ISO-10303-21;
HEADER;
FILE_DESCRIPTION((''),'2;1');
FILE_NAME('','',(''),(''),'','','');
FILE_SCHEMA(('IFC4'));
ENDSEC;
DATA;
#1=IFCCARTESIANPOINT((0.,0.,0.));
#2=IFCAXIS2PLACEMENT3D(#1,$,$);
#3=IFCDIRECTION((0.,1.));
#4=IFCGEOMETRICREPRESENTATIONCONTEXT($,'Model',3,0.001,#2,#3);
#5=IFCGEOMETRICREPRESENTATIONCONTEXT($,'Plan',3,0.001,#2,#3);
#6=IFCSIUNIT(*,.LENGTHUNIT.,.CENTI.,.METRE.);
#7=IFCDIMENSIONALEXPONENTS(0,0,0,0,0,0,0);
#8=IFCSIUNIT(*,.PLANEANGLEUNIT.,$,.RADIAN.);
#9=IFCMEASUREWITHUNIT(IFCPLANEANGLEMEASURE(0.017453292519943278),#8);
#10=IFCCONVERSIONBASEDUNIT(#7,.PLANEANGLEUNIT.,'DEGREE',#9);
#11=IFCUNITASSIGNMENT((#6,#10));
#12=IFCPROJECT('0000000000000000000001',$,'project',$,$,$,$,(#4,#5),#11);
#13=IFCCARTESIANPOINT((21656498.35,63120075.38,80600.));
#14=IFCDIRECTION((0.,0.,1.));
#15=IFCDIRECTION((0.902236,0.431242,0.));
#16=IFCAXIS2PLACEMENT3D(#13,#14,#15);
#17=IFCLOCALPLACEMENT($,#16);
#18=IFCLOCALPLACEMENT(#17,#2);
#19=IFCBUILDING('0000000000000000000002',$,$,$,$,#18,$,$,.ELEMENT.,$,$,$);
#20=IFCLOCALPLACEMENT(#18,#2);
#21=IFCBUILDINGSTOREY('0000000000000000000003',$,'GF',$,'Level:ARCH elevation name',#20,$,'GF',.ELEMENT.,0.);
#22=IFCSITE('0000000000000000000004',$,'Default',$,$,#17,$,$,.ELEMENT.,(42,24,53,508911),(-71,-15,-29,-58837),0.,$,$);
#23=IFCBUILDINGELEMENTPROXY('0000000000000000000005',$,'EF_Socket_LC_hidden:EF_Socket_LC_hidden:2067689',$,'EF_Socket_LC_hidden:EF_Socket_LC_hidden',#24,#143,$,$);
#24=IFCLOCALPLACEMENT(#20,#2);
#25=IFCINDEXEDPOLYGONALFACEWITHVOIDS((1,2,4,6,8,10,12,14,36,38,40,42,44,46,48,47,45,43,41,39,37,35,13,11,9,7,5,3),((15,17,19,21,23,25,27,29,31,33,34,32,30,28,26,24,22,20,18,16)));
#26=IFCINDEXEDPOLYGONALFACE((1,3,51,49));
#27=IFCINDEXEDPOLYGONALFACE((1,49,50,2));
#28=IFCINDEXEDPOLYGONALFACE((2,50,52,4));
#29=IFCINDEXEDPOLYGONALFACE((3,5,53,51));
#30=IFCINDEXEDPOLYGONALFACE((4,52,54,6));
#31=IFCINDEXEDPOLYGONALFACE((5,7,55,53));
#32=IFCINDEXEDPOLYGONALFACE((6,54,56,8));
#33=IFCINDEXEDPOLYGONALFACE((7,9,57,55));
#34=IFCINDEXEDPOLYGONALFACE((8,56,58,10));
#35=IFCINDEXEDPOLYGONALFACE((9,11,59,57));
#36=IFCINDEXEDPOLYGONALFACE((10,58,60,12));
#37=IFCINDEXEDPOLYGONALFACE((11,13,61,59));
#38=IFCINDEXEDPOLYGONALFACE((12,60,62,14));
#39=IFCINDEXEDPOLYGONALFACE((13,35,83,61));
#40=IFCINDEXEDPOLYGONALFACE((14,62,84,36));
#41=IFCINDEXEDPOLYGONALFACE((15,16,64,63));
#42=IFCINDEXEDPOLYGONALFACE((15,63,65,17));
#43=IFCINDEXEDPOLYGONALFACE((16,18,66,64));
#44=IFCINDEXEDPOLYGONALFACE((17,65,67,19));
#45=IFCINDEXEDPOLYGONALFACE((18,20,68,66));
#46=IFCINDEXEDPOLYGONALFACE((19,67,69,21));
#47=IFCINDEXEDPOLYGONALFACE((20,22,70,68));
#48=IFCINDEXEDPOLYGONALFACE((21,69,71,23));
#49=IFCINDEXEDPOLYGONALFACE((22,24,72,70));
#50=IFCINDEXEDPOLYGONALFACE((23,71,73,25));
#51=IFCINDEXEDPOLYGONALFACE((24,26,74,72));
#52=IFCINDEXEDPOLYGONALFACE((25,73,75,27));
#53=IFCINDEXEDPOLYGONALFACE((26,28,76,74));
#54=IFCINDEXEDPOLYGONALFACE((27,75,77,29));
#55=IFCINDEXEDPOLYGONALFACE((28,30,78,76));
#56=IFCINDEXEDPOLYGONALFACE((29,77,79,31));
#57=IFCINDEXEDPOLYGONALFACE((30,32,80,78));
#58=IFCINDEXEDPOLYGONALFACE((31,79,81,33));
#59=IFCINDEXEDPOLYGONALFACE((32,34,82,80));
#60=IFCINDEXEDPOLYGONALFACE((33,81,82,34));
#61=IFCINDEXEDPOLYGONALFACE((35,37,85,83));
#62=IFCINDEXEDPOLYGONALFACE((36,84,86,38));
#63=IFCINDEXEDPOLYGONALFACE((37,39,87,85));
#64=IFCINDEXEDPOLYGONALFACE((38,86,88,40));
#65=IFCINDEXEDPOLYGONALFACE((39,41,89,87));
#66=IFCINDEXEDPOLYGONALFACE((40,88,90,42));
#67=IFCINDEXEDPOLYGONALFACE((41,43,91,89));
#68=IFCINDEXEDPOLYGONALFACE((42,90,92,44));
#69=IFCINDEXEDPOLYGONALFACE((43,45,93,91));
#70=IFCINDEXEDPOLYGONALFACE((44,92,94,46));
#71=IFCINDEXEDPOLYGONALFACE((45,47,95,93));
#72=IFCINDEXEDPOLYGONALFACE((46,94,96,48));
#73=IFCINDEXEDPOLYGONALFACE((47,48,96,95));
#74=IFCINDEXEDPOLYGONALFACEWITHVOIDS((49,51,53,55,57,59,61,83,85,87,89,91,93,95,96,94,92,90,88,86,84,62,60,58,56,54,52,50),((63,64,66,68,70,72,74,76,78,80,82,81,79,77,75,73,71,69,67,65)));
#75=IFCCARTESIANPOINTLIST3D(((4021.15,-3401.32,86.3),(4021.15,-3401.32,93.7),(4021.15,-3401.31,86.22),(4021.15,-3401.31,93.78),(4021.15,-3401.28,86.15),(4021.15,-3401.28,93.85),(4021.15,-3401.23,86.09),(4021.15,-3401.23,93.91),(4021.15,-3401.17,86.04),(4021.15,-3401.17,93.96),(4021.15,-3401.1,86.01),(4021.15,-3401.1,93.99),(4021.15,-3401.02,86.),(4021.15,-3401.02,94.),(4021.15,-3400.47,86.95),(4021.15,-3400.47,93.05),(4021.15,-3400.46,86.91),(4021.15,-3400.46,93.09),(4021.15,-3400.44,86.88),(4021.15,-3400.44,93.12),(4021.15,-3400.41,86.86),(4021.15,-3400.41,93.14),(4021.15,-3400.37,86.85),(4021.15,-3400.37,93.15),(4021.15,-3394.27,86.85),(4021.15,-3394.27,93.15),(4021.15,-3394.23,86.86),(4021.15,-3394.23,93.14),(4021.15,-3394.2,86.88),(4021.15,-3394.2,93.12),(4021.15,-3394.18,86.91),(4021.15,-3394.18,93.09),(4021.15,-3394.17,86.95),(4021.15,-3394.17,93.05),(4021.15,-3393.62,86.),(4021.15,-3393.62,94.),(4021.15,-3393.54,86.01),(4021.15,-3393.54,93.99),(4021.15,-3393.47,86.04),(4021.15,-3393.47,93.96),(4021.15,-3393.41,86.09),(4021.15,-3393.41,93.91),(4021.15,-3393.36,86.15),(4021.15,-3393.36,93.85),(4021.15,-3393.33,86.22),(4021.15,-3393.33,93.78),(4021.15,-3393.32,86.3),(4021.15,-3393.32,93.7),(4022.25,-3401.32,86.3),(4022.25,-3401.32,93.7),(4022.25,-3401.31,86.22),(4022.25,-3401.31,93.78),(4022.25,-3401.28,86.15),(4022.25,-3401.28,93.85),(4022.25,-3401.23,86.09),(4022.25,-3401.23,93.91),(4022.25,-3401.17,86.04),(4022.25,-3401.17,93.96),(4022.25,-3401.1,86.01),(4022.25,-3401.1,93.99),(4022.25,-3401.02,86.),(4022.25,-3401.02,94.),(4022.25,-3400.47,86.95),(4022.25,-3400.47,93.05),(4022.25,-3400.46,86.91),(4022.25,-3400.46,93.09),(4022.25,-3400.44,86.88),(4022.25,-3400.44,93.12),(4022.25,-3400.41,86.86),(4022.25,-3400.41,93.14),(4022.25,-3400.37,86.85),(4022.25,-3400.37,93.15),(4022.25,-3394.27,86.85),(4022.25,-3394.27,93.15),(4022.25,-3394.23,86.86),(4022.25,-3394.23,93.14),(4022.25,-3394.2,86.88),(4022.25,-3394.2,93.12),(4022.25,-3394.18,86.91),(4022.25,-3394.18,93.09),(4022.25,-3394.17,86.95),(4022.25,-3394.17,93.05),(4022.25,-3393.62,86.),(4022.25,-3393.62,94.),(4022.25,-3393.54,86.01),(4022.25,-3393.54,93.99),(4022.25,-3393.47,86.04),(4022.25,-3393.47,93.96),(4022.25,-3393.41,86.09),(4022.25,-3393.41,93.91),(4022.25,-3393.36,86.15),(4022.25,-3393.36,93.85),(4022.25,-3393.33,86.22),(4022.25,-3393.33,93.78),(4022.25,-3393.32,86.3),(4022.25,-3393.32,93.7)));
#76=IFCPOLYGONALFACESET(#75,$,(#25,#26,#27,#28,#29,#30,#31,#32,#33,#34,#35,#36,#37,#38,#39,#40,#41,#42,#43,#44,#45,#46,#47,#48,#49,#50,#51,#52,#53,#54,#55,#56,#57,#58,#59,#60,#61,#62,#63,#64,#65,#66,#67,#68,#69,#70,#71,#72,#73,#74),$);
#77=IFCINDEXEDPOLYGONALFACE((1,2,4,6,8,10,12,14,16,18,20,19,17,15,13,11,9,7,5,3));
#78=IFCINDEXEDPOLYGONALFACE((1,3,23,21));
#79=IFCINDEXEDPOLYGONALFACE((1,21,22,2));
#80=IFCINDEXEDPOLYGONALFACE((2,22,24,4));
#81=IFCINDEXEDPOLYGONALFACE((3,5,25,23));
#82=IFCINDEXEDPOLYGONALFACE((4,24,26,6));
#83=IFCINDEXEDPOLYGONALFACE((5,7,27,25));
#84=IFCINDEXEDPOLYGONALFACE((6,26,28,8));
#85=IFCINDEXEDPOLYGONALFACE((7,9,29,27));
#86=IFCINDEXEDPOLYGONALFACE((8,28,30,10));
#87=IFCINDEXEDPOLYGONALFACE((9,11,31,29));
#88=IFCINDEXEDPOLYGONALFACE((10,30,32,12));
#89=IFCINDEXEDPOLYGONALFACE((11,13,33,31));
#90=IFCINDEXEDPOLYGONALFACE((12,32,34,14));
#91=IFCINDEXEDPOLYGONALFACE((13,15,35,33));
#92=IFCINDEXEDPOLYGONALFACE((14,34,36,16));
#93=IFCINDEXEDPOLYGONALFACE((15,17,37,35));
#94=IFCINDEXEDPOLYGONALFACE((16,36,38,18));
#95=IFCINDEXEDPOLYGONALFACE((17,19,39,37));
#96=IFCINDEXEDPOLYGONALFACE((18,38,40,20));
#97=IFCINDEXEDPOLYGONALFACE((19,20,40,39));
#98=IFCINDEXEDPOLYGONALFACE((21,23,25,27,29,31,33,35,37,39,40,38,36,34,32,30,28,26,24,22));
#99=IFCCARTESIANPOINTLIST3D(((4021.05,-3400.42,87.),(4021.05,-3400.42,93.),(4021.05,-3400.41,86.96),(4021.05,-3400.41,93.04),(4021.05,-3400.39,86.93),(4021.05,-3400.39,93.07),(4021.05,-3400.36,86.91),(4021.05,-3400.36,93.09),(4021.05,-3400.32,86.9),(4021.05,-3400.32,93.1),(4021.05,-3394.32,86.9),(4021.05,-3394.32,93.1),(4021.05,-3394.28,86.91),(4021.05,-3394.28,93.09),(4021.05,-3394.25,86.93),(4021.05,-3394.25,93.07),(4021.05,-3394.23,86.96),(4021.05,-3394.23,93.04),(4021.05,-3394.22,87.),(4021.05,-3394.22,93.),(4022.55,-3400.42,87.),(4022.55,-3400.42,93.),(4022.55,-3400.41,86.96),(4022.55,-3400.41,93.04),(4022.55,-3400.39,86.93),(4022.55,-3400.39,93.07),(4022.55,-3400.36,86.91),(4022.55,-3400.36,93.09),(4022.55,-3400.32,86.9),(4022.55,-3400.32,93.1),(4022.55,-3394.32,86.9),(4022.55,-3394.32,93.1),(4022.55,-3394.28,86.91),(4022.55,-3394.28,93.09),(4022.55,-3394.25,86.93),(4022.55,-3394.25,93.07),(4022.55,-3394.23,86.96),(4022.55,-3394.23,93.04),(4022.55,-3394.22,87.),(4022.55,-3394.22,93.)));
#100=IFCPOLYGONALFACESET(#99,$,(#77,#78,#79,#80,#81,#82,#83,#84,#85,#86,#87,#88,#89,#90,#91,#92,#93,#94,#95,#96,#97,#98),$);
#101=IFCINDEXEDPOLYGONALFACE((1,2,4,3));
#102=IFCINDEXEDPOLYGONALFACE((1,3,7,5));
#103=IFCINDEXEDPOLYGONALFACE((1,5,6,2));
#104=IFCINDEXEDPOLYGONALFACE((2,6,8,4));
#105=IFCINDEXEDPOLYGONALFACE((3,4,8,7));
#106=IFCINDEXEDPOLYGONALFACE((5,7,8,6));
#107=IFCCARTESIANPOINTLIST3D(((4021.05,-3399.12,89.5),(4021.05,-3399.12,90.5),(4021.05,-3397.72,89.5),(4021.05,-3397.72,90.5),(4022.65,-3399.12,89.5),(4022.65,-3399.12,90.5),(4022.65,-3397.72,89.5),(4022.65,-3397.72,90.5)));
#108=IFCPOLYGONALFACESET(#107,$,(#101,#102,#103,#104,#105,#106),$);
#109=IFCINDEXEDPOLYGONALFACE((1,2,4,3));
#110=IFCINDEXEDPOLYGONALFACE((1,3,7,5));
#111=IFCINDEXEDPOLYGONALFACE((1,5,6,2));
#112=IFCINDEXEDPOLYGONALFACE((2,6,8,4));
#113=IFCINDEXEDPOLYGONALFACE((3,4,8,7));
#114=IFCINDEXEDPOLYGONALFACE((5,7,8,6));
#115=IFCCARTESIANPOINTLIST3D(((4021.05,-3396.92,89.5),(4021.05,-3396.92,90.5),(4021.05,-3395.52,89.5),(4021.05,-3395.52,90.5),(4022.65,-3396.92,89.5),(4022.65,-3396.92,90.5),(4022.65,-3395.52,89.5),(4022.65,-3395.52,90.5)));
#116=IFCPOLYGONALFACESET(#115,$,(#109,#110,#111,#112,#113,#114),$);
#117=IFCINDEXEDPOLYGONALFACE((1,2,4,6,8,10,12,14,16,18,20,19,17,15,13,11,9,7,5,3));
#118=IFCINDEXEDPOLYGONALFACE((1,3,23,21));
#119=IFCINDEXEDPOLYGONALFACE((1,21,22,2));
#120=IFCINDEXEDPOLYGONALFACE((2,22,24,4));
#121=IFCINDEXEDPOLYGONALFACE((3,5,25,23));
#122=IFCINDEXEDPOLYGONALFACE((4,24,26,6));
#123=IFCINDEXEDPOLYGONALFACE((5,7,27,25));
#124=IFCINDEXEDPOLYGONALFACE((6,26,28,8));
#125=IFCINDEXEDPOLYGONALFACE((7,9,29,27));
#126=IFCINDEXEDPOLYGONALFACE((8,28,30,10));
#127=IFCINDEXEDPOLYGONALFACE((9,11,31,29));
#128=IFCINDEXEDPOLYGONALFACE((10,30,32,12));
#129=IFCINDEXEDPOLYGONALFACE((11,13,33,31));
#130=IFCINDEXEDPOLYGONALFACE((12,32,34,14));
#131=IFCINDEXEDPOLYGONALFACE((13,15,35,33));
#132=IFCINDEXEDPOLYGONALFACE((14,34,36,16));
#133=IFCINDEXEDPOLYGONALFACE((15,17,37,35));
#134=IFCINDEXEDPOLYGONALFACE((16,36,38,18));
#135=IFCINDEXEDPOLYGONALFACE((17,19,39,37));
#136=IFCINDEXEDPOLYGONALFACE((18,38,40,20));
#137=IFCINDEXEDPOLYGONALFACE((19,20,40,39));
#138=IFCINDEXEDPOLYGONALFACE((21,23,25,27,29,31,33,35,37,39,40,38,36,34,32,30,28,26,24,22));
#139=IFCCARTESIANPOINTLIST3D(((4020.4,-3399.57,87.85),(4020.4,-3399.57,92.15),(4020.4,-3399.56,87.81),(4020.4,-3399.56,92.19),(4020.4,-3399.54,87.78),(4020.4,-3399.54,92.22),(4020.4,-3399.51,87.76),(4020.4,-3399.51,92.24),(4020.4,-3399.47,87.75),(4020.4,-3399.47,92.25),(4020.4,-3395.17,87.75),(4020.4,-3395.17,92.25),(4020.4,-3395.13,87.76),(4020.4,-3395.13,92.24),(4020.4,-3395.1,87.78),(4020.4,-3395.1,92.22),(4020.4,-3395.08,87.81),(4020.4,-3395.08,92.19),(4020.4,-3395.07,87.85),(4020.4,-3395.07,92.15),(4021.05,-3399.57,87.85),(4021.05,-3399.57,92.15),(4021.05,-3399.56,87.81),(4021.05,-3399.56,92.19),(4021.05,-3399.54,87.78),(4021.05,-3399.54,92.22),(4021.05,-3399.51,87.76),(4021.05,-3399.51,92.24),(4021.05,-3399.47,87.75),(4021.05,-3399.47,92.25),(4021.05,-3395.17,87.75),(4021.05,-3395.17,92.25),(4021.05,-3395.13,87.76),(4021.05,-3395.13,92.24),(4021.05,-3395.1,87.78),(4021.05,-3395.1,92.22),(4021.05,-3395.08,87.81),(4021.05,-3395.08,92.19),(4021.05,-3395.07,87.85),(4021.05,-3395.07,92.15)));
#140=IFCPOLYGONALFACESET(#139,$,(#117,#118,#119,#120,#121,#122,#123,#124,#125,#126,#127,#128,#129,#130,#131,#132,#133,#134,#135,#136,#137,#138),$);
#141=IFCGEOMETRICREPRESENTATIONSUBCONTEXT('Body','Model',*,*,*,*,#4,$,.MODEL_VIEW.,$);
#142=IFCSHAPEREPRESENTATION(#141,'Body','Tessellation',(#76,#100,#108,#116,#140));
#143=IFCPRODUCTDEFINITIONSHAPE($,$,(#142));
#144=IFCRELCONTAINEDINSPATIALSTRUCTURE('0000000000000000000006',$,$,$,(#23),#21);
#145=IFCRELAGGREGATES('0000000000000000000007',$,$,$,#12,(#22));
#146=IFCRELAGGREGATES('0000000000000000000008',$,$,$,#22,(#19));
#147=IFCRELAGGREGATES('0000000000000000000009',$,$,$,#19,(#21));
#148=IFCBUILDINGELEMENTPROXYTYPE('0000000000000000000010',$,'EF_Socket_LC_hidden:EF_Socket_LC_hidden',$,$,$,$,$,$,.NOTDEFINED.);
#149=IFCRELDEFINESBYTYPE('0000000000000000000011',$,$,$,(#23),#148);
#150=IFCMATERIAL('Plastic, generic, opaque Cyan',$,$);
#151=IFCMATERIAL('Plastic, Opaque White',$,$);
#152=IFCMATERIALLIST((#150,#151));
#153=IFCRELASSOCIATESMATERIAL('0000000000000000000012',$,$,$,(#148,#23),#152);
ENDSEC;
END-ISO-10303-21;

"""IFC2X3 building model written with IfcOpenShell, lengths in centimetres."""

from ifc_helpers import new_model, entity, si_unit, converted_unit, direction, frame, frame_2d, origin, place, context, subcontext, project, spatial, polyline, circle_curve, parameter, trimmed, segment, composite_curve, rectangle, outline, extrude, source, transform, mapped, material, material_list, type_object, type_shapes, element, save


model = new_model("IFC2X3")

# Units and contexts
model_context = context("Model", 3, precision=0.001, world=origin(), true_north=direction((0.0, 1.0)))
plan_context = context("Plan", 3, precision=0.001, world=origin(), true_north=direction((0.0, 1.0)))
body_context = subcontext(model_context, "Body", "Model", "MODEL_VIEW")
ifc_project = project(units=[si_unit("LENGTHUNIT", "METRE", prefix="CENTI"), converted_unit("PLANEANGLEUNIT", "DEGREE", entity("IfcPlaneAngleMeasure", 0.017453292519943278), si_unit("PLANEANGLEUNIT", "RADIAN"), dimensions=[0, 0, 0, 0, 0, 0, 0])], contexts=[model_context, plan_context])

# Site, building, storey
site_placement = place(None, frame((21656498.35, 63120075.38, 80600.0), z_axis=(0.0, 0.0, 1.0), x_axis=(0.902236, 0.431242, 0.0)))
site = spatial("IfcSite", under=ifc_project, at=site_placement, Name="Default", CompositionType="ELEMENT", RefLatitude=(42, 24, 53, 508911), RefLongitude=(-71, -15, -29, -58837), RefElevation=0.0)
building_placement = place(site_placement, origin())
building = spatial("IfcBuilding", under=site, at=building_placement, CompositionType="ELEMENT")
storey_placement = place(building_placement, origin())
storey = spatial("IfcBuildingStorey", under=building, at=storey_placement, Name="GF", ObjectType="Level:ARCH elevation name", LongName="GF", CompositionType="ELEMENT", Elevation=0.0)

# Building element proxy
ifc_material_1 = material(Name="Plastic, generic, opaque Cyan")
ifc_material_2 = material(Name="Plastic, Opaque White")
ifc_material_list_1 = material_list([ifc_material_1, ifc_material_2])
building_element_proxy_type_1 = type_object("IfcBuildingElementProxyType", Name="EF_Socket_LC_hidden:EF_Socket_LC_hidden", PredefinedType="NOTDEFINED", material=ifc_material_list_1)
shared_shape_1 = source(origin(), body_context, "Body", "SweptSolid", [
    extrude(outline(composite_curve([segment(trimmed(circle_curve(frame_2d((3.7, -3.7), x_axis=(1.0, 0.0)), 0.3), [parameter(270.0)], [parameter(0.0)], True, "PARAMETER"), True, "CONTINUOUS"), segment(polyline([(4.0, -3.7), (4.0, 3.7)]), True, "CONTINUOUS"), segment(trimmed(circle_curve(frame_2d((3.7, 3.7), x_axis=(1.0, 0.0)), 0.3), [parameter(0.0)], [parameter(90.0)], True, "PARAMETER"), True, "CONTINUOUS"), segment(polyline([(3.7, 4.0), (-3.7, 4.0)]), True, "CONTINUOUS"), segment(trimmed(circle_curve(frame_2d((-3.7, 3.7), x_axis=(1.0, 0.0)), 0.3), [parameter(90.0)], [parameter(180.0)], True, "PARAMETER"), True, "CONTINUOUS"), segment(polyline([(-4.0, 3.7), (-4.0, -3.7)]), True, "CONTINUOUS"), segment(trimmed(circle_curve(frame_2d((-3.7, -3.7), x_axis=(1.0, 0.0)), 0.3), [parameter(180.0)], [parameter(270.0)], True, "PARAMETER"), True, "CONTINUOUS"), segment(polyline([(-3.7, -4.0), (3.7, -4.0)]), True, "CONTINUOUS")], self_intersect=False), holes=[composite_curve([segment(polyline([(-3.15, -3.05), (-3.15, 3.05)]), True, "CONTINUOUS"), segment(trimmed(circle_curve(frame_2d((-3.05, 3.05), x_axis=(1.0, 0.0)), 0.1), [parameter(90.0)], [parameter(180.0)], True, "PARAMETER"), False, "CONTINUOUS"), segment(polyline([(-3.05, 3.15), (3.05, 3.15)]), True, "CONTINUOUS"), segment(trimmed(circle_curve(frame_2d((3.05, 3.05), x_axis=(1.0, 0.0)), 0.1), [parameter(360.0)], [parameter(90.0)], True, "PARAMETER"), False, "CONTINUOUS"), segment(polyline([(3.15, 3.05), (3.15, -3.05)]), True, "CONTINUOUS"), segment(trimmed(circle_curve(frame_2d((3.05, -3.05), x_axis=(1.0, 0.0)), 0.1), [parameter(270.0)], [parameter(360.0)], True, "PARAMETER"), False, "CONTINUOUS"), segment(polyline([(3.05, -3.15), (-3.05, -3.15)]), True, "CONTINUOUS"), segment(trimmed(circle_curve(frame_2d((-3.05, -3.05), x_axis=(1.0, 0.0)), 0.1), [parameter(180.0)], [parameter(270.0)], True, "PARAMETER"), False, "CONTINUOUS")], self_intersect=False)]), frame((0.0, 0.0, 0.0), z_axis=(0.0, 1.0, 0.0), x_axis=(1.0, 0.0, 0.0)), (0.0, 0.0, 1.0), 1.1),
    extrude(outline(composite_curve([segment(trimmed(circle_curve(frame_2d((3.0, -3.0), x_axis=(1.0, 0.0)), 0.1), [parameter(270.0)], [parameter(0.0)], True, "PARAMETER"), True, "CONTINUOUS"), segment(polyline([(3.1, -3.0), (3.1, 3.0)]), True, "CONTINUOUS"), segment(trimmed(circle_curve(frame_2d((3.0, 3.0), x_axis=(1.0, 0.0)), 0.1), [parameter(0.0)], [parameter(90.0)], True, "PARAMETER"), True, "CONTINUOUS"), segment(polyline([(3.0, 3.1), (-3.0, 3.1)]), True, "CONTINUOUS"), segment(trimmed(circle_curve(frame_2d((-3.0, 3.0), x_axis=(1.0, 0.0)), 0.1), [parameter(90.0)], [parameter(180.0)], True, "PARAMETER"), True, "CONTINUOUS"), segment(polyline([(-3.1, 3.0), (-3.1, -3.0)]), True, "CONTINUOUS"), segment(trimmed(circle_curve(frame_2d((-3.0, -3.0), x_axis=(1.0, 0.0)), 0.1), [parameter(180.0)], [parameter(270.0)], True, "PARAMETER"), True, "CONTINUOUS"), segment(polyline([(-3.0, -3.1), (3.0, -3.1)]), True, "CONTINUOUS")], self_intersect=False)), frame((0.0, -0.1, 0.0), z_axis=(0.0, 1.0, 0.0), x_axis=(1.0, 0.0, 0.0)), (0.0, 0.0, 1.0), 1.5),
    extrude(rectangle(XDim=1.6, YDim=1.4, at=frame_2d((0.0, 0.0), x_axis=(1.0, 0.0))), frame((1.1, 0.7, -0.5), z_axis=(0.0, 0.0, 1.0), x_axis=(0.0, -1.0, 0.0)), (0.0, 0.0, 1.0), 1.0),
    extrude(rectangle(XDim=1.6, YDim=1.4, at=frame_2d((0.0, 0.0), x_axis=(1.0, 0.0))), frame((-1.1, 0.7, -0.5), z_axis=(0.0, 0.0, 1.0), x_axis=(0.0, -1.0, 0.0)), (0.0, 0.0, 1.0), 1.0),
    extrude(outline(composite_curve([segment(trimmed(circle_curve(frame_2d((2.15, -2.15), x_axis=(1.0, 0.0)), 0.1), [parameter(270.0)], [parameter(0.0)], True, "PARAMETER"), True, "CONTINUOUS"), segment(polyline([(2.25, -2.15), (2.25, 2.15)]), True, "CONTINUOUS"), segment(trimmed(circle_curve(frame_2d((2.15, 2.15), x_axis=(1.0, 0.0)), 0.1), [parameter(0.0)], [parameter(90.0)], True, "PARAMETER"), True, "CONTINUOUS"), segment(polyline([(2.15, 2.25), (-2.15, 2.25)]), True, "CONTINUOUS"), segment(trimmed(circle_curve(frame_2d((-2.15, 2.15), x_axis=(1.0, 0.0)), 0.1), [parameter(90.0)], [parameter(180.0)], True, "PARAMETER"), True, "CONTINUOUS"), segment(polyline([(-2.25, 2.15), (-2.25, -2.15)]), True, "CONTINUOUS"), segment(trimmed(circle_curve(frame_2d((-2.15, -2.15), x_axis=(1.0, 0.0)), 0.1), [parameter(180.0)], [parameter(270.0)], True, "PARAMETER"), True, "CONTINUOUS"), segment(polyline([(-2.15, -2.25), (2.15, -2.25)]), True, "CONTINUOUS")], self_intersect=False)), frame((0.0, -0.75, 0.0), z_axis=(0.0, 1.0, 0.0), x_axis=(1.0, 0.0, 0.0)), (0.0, 0.0, 1.0), 0.65),
])
type_shapes(building_element_proxy_type_1, [shared_shape_1])
for number, where, z_axis, x_axis, name in (
    (1, (4021.15, -3397.32, 90.0), (0.0, 0.0, 1.0), (0.0, -1.0, 0.0), "EF_Socket_LC_hidden:EF_Socket_LC_hidden:2067689"),
):
    element("IfcBuildingElementProxy", number, at=place(storey_placement, frame(where, z_axis=z_axis, x_axis=x_axis)), inside=storey, type_object=building_element_proxy_type_1, material=ifc_material_list_1, Name=name, ObjectType="EF_Socket_LC_hidden:EF_Socket_LC_hidden", context=body_context, shape_type="MappedRepresentation", body=[
        mapped(shared_shape_1, transform((0.0, 0.0, 0.0), scale=1.0)),
    ])

save(model, "model.ifc")
